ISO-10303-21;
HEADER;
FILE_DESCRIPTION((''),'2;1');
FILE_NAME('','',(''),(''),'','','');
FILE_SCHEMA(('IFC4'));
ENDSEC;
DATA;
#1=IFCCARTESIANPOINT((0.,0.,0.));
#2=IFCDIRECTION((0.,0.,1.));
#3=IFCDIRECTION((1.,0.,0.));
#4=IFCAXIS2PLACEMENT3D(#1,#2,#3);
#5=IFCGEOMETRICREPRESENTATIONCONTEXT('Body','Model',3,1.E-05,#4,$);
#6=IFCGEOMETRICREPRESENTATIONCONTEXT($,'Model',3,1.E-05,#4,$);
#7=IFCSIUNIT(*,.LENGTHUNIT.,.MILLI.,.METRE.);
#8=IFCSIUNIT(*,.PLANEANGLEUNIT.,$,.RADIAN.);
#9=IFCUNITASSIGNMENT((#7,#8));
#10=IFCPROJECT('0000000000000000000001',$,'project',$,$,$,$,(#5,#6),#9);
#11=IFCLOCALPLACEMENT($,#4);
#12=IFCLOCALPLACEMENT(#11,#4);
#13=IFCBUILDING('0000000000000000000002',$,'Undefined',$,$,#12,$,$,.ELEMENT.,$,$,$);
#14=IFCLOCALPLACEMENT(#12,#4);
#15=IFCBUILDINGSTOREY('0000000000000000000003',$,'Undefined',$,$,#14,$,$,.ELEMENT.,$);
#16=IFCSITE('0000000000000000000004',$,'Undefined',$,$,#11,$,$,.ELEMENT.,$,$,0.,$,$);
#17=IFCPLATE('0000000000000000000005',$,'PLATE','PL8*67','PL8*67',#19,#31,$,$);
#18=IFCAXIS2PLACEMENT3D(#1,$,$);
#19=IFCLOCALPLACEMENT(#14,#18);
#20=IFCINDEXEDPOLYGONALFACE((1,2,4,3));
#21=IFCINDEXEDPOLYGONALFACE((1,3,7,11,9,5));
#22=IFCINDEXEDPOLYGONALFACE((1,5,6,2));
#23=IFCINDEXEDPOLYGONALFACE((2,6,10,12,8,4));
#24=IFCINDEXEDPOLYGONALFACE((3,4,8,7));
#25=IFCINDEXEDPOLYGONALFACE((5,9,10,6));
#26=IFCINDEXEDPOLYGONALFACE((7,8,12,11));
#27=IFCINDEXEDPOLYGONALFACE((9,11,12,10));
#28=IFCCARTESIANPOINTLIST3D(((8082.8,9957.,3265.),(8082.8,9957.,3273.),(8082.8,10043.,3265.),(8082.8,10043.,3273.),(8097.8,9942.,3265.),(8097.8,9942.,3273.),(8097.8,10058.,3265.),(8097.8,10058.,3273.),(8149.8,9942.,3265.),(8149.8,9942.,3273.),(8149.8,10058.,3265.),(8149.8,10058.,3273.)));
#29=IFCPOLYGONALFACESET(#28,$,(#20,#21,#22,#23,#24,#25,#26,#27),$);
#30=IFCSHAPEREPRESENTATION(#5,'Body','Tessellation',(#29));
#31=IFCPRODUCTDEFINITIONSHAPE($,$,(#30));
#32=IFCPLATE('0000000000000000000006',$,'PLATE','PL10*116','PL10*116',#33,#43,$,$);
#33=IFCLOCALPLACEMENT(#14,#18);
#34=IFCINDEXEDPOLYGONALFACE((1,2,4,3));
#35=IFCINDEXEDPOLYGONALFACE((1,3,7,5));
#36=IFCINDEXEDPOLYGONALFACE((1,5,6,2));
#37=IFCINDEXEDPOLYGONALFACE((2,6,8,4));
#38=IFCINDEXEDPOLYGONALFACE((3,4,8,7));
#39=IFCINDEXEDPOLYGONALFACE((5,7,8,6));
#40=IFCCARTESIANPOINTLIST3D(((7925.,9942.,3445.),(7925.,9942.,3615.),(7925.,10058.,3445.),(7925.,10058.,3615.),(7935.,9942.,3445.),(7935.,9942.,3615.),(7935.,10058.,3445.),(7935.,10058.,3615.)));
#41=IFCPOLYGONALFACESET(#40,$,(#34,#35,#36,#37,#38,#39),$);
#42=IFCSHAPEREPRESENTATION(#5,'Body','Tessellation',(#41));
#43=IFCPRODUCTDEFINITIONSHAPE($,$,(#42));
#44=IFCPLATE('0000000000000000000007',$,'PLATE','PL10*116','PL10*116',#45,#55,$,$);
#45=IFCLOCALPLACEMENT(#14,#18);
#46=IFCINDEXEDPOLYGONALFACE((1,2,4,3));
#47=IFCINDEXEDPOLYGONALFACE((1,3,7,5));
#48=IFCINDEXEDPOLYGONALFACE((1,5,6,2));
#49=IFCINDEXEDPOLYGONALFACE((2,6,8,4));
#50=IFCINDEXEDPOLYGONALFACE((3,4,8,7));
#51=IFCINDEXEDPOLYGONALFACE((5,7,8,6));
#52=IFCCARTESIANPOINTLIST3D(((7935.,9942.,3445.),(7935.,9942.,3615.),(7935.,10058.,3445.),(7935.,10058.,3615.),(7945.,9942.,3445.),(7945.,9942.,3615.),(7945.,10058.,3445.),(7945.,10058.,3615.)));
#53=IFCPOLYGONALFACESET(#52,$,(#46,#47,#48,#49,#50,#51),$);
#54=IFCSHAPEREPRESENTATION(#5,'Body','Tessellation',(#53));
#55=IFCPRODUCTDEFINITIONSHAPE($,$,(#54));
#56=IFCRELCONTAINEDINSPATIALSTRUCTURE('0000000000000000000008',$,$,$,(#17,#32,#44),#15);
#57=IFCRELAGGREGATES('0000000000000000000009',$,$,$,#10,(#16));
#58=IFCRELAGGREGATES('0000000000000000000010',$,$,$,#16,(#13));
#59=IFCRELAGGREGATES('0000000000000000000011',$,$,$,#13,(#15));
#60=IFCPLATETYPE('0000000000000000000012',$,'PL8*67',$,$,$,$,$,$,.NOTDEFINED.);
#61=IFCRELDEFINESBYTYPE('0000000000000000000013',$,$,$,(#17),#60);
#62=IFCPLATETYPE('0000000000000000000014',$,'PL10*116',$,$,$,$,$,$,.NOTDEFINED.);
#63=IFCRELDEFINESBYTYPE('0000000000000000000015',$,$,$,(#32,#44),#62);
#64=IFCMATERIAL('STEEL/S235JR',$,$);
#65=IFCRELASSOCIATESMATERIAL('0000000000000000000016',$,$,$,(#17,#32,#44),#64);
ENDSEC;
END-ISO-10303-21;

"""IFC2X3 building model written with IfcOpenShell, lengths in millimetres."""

from ifc_helpers import new_model, si_unit, frame, origin_with_axes, place, context, project, spatial, polyline, outline, extrude, material, type_object, element, save


model = new_model("IFC2X3")

# Units and contexts
model_context_1 = context("Model", 3, precision=1e-05, world=origin_with_axes(), identifier="Body")
model_context_2 = context("Model", 3, precision=1e-05, world=origin_with_axes())
ifc_project = project(units=[si_unit("LENGTHUNIT", "METRE", prefix="MILLI"), si_unit("PLANEANGLEUNIT", "RADIAN")], contexts=[model_context_1, model_context_2])

# Site, building, storey
site_placement = place(None, origin_with_axes())
site = spatial("IfcSite", under=ifc_project, at=site_placement, Name="Undefined", CompositionType="ELEMENT", RefElevation=0.0)
building_placement = place(site_placement, origin_with_axes())
building = spatial("IfcBuilding", under=site, at=building_placement, Name="Undefined", CompositionType="ELEMENT")
storey_placement = place(building_placement, origin_with_axes())
storey = spatial("IfcBuildingStorey", under=building, at=storey_placement, Name="Undefined", CompositionType="ELEMENT")

# Shared definitions
ifc_material = material(Name="STEEL/S235JR")

# Plates
plate_type_1 = type_object("IfcPlateType", Name="PL8*67", PredefinedType="NOTDEFINED")
plate_1_placement = place(storey_placement, frame((8082.8, 9942.0, 3269.0), z_axis=(0.0, 0.0, 1.0), x_axis=(1.0, 0.0, 0.0)))
element("IfcPlate", 1, at=plate_1_placement, inside=storey, type_object=plate_type_1, material=ifc_material, Name="PLATE", Description="PL8*67", ObjectType="PL8*67", context=model_context_1, shape_type="SweptSolid", body=[
    extrude(outline(polyline([(0.0, 15.0), (15.0, 0.0), (67.0, 0.0), (67.0, 116.0), (15.0, 116.0), (0.0, 101.0), (0.0, 15.0)])), frame((0.0, 0.0, -4.0), z_axis=(0.0, 0.0, 1.0), x_axis=(1.0, 0.0, 0.0)), (0.0, 0.0, 1.0), 8.0),
])
plate_type_2 = type_object("IfcPlateType", Name="PL10*116", PredefinedType="NOTDEFINED")
for number, where, z_axis, x_axis, name in (
    (2, (7930.0, 10058.0, 3615.0), (1.0, 0.0, 0.0), (0.0, -1.0, 0.0), "PLATE"),
    (3, (7940.0, 10058.0, 3615.0), (1.0, 0.0, 0.0), (0.0, -1.0, 0.0), "PLATE"),
):
    element("IfcPlate", number, at=place(storey_placement, frame(where, z_axis=z_axis, x_axis=x_axis)), inside=storey, type_object=plate_type_2, material=ifc_material, Name=name, Description="PL10*116", ObjectType="PL10*116", context=model_context_1, shape_type="SweptSolid", body=[
        extrude(outline(polyline([(0.0, 0.0), (116.0, 0.0), (116.0, 170.0), (0.0, 170.0), (0.0, 0.0)])), frame((0.0, 0.0, -5.0), z_axis=(0.0, 0.0, 1.0), x_axis=(1.0, 0.0, 0.0)), (0.0, 0.0, 1.0), 10.0),
    ])

save(model, "model.ifc")
